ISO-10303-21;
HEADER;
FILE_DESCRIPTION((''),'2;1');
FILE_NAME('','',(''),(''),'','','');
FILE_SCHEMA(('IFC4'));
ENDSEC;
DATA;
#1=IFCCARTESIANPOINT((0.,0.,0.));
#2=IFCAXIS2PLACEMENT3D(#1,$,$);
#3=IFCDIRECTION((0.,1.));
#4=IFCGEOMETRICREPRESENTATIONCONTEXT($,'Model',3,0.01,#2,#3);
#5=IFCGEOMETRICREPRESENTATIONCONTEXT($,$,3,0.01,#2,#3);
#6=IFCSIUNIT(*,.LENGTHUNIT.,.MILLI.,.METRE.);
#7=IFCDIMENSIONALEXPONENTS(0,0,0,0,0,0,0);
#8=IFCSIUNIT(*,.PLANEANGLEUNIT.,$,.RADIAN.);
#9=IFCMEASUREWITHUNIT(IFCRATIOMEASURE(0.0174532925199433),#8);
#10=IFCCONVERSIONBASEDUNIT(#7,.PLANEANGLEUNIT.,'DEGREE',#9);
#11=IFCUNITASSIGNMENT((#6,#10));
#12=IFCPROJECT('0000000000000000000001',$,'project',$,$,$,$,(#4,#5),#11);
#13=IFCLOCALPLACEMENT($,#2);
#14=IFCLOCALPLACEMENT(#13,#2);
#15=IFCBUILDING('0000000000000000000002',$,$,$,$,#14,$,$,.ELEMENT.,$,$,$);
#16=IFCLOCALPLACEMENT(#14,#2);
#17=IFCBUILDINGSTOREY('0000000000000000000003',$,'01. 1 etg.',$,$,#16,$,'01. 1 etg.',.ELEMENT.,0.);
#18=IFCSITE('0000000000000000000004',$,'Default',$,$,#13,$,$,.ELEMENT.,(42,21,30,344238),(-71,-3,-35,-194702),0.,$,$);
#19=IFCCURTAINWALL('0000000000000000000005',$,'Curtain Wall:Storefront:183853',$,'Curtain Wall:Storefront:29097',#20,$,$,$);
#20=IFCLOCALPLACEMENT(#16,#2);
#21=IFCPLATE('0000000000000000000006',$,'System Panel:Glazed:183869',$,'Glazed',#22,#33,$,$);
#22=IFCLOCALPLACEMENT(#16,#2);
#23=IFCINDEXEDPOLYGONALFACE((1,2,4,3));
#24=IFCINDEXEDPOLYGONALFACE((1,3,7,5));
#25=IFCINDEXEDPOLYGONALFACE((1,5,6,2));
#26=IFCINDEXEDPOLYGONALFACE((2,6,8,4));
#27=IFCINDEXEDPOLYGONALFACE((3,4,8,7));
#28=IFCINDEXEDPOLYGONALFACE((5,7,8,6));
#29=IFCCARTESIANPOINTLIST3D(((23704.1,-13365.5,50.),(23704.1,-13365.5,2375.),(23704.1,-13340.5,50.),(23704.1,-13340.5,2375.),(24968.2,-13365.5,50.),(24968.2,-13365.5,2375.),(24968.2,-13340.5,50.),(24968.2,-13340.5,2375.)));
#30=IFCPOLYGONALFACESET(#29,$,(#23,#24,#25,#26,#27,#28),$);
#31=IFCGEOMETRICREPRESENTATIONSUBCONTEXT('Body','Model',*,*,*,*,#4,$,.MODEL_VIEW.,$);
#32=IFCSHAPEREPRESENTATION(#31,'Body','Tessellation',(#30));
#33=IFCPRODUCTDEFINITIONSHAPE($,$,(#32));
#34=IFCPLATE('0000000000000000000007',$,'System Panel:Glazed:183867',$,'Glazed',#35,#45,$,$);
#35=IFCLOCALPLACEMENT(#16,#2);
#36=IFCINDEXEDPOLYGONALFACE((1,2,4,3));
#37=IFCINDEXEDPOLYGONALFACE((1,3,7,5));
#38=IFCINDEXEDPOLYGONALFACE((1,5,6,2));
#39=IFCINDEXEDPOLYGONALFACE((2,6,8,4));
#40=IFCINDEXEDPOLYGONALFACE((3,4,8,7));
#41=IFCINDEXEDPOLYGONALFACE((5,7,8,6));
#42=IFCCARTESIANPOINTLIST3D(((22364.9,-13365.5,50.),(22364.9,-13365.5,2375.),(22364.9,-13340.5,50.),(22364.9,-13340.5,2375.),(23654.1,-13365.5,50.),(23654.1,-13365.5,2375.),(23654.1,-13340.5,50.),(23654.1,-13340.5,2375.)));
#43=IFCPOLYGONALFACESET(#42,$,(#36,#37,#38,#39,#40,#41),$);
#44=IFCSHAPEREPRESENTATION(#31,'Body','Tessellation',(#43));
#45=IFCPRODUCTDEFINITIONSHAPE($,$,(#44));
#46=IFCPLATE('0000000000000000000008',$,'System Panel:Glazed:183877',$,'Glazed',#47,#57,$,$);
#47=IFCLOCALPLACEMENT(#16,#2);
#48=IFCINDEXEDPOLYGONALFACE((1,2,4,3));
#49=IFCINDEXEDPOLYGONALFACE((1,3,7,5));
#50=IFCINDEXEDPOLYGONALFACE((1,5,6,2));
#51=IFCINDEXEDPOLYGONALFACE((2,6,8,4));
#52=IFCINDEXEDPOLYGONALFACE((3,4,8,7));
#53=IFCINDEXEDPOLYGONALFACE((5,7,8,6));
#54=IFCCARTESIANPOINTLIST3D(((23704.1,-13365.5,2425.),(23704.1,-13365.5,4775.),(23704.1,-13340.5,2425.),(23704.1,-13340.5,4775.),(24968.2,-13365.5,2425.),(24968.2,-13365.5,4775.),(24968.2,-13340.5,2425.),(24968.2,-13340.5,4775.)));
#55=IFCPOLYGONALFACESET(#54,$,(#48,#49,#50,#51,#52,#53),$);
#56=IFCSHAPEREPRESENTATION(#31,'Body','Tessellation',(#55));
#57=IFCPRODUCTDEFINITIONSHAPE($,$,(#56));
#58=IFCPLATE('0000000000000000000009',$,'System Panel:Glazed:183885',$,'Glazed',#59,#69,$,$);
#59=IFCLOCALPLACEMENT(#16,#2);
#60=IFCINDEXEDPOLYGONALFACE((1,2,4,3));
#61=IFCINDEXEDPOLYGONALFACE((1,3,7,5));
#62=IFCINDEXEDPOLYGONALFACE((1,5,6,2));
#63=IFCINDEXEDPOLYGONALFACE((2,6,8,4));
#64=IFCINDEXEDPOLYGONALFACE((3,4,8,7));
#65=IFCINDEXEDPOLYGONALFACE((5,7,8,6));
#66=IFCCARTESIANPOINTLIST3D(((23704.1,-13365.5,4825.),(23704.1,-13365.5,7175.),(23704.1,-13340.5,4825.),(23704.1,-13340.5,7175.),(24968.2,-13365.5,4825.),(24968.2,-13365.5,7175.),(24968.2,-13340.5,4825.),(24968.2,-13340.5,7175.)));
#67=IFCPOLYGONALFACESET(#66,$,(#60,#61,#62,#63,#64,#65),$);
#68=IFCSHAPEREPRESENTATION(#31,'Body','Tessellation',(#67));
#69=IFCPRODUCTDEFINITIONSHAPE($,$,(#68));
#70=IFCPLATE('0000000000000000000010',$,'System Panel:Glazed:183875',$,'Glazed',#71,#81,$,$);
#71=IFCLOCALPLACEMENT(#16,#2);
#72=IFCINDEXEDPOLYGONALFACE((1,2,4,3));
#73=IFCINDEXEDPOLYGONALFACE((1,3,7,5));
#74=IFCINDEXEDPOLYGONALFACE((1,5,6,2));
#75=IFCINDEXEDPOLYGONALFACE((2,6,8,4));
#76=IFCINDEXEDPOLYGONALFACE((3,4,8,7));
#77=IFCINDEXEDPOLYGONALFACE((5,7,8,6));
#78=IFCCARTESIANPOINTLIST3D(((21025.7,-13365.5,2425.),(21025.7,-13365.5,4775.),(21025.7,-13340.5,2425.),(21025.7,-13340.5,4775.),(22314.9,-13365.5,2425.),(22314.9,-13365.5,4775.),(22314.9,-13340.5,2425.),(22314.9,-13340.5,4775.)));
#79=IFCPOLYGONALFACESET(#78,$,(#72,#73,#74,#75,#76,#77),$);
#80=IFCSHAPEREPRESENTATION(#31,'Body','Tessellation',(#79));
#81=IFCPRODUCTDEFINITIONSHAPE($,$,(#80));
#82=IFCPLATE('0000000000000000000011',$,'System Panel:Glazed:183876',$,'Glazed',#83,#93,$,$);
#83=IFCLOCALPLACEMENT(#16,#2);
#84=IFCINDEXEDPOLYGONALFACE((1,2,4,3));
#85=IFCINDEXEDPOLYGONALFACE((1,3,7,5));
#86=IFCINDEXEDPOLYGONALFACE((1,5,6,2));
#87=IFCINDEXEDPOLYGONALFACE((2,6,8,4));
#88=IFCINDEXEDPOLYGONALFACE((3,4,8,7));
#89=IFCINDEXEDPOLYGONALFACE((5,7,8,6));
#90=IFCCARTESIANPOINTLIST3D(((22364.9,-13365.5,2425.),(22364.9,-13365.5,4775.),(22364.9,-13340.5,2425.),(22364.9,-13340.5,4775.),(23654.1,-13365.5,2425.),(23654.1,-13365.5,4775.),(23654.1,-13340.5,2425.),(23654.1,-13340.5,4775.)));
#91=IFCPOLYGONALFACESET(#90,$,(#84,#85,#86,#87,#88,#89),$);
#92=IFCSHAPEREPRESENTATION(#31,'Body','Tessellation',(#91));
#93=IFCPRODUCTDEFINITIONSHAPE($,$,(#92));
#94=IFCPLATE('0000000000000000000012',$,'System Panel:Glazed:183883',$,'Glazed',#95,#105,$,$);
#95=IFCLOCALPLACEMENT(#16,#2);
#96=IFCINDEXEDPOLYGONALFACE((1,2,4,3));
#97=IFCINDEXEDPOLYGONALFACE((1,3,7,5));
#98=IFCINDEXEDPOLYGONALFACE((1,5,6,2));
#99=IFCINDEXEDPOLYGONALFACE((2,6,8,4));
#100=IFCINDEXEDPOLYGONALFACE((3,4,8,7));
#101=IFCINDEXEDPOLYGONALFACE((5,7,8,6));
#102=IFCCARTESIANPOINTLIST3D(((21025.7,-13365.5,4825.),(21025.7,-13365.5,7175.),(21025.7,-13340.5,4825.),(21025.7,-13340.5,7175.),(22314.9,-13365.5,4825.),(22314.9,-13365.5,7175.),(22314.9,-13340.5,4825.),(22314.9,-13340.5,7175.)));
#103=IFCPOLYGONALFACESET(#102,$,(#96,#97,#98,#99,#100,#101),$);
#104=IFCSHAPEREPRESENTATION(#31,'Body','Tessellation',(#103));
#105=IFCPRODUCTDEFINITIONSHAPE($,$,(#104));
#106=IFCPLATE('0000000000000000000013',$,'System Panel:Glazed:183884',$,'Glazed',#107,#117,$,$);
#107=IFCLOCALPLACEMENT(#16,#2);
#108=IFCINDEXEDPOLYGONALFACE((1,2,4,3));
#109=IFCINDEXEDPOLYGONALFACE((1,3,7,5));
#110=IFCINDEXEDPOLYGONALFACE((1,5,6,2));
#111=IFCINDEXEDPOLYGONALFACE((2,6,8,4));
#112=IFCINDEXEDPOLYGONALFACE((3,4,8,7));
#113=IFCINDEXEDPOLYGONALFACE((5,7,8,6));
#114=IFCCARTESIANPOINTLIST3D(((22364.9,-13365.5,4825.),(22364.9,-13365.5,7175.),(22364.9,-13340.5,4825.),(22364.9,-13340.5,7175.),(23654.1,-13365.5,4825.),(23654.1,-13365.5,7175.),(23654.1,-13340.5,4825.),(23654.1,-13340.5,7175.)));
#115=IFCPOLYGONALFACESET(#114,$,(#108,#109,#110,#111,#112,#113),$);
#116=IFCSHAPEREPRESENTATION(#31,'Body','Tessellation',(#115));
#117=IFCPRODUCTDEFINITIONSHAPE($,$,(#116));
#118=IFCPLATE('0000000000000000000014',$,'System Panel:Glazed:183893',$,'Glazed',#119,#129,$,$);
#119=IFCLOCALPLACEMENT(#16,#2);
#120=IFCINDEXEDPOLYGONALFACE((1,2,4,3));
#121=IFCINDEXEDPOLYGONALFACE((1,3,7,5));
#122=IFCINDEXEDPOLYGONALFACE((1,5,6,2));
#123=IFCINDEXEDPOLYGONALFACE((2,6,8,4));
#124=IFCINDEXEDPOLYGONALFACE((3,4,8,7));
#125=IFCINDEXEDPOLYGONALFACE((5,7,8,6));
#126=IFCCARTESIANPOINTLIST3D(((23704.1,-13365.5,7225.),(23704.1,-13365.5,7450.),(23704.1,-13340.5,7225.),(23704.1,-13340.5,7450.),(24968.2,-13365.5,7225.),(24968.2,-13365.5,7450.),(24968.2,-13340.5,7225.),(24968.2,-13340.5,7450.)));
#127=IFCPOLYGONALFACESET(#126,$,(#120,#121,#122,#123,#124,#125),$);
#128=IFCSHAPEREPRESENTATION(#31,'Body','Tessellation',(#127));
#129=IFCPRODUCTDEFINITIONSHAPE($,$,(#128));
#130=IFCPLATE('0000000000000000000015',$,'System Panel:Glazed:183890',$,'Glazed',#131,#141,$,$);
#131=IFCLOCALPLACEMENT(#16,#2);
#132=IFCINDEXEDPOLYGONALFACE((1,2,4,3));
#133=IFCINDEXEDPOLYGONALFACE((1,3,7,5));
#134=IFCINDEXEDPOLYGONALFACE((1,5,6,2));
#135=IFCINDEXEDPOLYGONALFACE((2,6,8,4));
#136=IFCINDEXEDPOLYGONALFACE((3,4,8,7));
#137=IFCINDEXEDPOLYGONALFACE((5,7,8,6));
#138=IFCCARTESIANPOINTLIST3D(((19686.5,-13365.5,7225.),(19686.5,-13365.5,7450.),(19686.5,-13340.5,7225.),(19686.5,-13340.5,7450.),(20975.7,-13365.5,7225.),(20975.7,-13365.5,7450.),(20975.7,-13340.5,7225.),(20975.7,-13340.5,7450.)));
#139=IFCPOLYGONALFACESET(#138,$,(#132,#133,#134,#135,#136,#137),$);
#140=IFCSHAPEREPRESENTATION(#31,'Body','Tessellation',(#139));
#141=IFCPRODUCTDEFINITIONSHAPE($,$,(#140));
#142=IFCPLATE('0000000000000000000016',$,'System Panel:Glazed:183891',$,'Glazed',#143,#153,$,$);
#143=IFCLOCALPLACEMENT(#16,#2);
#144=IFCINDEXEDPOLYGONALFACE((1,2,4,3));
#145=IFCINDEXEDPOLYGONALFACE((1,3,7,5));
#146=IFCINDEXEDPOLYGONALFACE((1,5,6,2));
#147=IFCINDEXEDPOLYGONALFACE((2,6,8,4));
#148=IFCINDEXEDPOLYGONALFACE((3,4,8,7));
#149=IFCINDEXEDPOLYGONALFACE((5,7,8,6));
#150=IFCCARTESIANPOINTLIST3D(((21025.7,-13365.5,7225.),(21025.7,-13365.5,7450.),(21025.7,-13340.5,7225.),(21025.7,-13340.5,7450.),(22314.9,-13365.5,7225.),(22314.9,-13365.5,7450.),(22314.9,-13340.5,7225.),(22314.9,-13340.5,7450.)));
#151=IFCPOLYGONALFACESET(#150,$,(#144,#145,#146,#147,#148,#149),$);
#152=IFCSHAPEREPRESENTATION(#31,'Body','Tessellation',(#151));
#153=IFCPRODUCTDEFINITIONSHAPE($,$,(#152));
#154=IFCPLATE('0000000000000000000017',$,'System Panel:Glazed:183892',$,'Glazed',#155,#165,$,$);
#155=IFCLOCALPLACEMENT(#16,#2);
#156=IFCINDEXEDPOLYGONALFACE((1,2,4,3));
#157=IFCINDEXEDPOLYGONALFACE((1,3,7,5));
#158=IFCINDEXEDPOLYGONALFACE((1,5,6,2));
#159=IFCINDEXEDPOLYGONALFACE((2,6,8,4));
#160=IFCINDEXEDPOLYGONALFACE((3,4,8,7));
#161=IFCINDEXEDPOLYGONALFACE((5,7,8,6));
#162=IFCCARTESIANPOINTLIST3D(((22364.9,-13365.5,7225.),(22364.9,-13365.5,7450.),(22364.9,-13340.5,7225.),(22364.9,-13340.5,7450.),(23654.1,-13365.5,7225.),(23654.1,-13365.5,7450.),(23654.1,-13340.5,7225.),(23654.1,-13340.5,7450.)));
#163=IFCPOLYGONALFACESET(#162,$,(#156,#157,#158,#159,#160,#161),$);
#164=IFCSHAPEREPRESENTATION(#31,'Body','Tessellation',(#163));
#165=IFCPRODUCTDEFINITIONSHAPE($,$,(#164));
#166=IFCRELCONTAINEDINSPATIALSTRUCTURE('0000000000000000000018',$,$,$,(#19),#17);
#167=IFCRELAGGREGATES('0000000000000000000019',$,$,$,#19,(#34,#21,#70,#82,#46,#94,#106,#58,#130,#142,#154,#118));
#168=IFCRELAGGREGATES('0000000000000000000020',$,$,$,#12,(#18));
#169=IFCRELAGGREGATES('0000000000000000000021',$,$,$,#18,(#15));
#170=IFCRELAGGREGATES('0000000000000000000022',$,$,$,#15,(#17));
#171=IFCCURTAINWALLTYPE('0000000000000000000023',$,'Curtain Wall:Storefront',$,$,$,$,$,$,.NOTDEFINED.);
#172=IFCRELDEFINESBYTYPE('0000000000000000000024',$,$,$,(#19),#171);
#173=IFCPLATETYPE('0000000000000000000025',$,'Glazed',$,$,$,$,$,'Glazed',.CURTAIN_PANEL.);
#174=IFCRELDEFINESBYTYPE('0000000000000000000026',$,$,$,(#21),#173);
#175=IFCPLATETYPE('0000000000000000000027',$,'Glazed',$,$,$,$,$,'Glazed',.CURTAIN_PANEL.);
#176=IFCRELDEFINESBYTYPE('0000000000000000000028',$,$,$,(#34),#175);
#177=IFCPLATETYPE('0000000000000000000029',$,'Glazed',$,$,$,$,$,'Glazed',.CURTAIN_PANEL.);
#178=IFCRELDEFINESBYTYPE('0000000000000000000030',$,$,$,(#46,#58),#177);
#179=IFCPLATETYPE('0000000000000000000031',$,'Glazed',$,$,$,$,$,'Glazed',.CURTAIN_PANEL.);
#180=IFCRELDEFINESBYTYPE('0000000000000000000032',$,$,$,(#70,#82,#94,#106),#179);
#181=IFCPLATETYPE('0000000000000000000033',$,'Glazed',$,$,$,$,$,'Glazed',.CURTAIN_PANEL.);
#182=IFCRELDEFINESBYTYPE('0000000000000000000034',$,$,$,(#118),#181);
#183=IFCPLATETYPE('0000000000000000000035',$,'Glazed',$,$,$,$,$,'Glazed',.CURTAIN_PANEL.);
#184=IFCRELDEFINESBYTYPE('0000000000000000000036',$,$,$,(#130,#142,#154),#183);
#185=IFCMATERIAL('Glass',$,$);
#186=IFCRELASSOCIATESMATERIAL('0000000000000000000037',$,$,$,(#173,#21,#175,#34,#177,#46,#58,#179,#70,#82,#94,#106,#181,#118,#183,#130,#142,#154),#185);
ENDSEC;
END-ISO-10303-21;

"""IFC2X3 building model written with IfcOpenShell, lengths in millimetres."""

from ifc_helpers import new_model, entity, si_unit, converted_unit, direction, frame, origin, origin_2d_with_axis, place, context, subcontext, project, spatial, rectangle, extrude, source, transform, mapped, material, type_object, type_shapes, element, aggregate, save


model = new_model("IFC2X3")

# Units and contexts
model_context = context("Model", 3, precision=0.01, world=origin(), true_north=direction((0.0, 1.0)))
context_of_model = context(None, 3, precision=0.01, world=origin(), true_north=direction((0.0, 1.0)))
body_context = subcontext(model_context, "Body", "Model", "MODEL_VIEW")
ifc_project = project(units=[si_unit("LENGTHUNIT", "METRE", prefix="MILLI"), converted_unit("PLANEANGLEUNIT", "DEGREE", entity("IfcRatioMeasure", 0.0174532925199433), si_unit("PLANEANGLEUNIT", "RADIAN"), dimensions=[0, 0, 0, 0, 0, 0, 0])], contexts=[model_context, context_of_model])

# Site, building, storey
site_placement = place(None, origin())
site = spatial("IfcSite", under=ifc_project, at=site_placement, Name="Default", CompositionType="ELEMENT", RefLatitude=(42, 21, 30, 344238), RefLongitude=(-71, -3, -35, -194702), RefElevation=0.0)
building_placement = place(site_placement, origin())
building = spatial("IfcBuilding", under=site, at=building_placement, CompositionType="ELEMENT")
storey_placement = place(building_placement, origin())
storey = spatial("IfcBuildingStorey", under=building, at=storey_placement, Name="01. 1 etg.", LongName="01. 1 etg.", CompositionType="ELEMENT", Elevation=0.0)

# Curtain wall, plates
curtain_wall_type = type_object("IfcCurtainWallType", Name="Curtain Wall:Storefront", PredefinedType="NOTDEFINED")
curtain_wall_placement = place(storey_placement, origin())
curtain_wall = element("IfcCurtainWall", 1, at=curtain_wall_placement, inside=storey, type_object=curtain_wall_type, Name="Curtain Wall:Storefront:183853", ObjectType="Curtain Wall:Storefront:29097")
ifc_material_1 = material(Name="Glass")
plate_type_1 = type_object("IfcPlateType", Name="Glazed", ElementType="Glazed", PredefinedType="CURTAIN_PANEL", material=ifc_material_1)
shared_shape_1 = source(origin(), body_context, "Body", "SweptSolid", [
    extrude(rectangle(XDim=25.0, YDim=1264.2, at=origin_2d_with_axis()), frame((632.1, 12.5, 0.0), z_axis=(0.0, 0.0, 1.0), x_axis=(0.0, 1.0, 0.0)), (0.0, 0.0, 1.0), 2325.0),
])
type_shapes(plate_type_1, [shared_shape_1])
plate_1_placement = place(curtain_wall_placement, frame((23704.1, -13365.5, 50.0)))
plate_1 = element("IfcPlate", 2, at=plate_1_placement, type_object=plate_type_1, material=ifc_material_1, Name="System Panel:Glazed:183869", ObjectType="Glazed", context=body_context, shape_type="MappedRepresentation", body=[
    mapped(shared_shape_1, transform((0.0, 0.0, 0.0), scale=1.0)),
])
plate_type_2 = type_object("IfcPlateType", Name="Glazed", ElementType="Glazed", PredefinedType="CURTAIN_PANEL", material=ifc_material_1)
shared_shape_2 = source(origin(), body_context, "Body", "SweptSolid", [
    extrude(rectangle(XDim=25.0, YDim=1289.2, at=origin_2d_with_axis()), frame((644.6, 12.5, 0.0), z_axis=(0.0, 0.0, 1.0), x_axis=(0.0, 1.0, 0.0)), (0.0, 0.0, 1.0), 2325.0),
])
type_shapes(plate_type_2, [shared_shape_2])
plate_2_placement = place(curtain_wall_placement, frame((22364.9, -13365.5, 50.0)))
plate_2 = element("IfcPlate", 3, at=plate_2_placement, type_object=plate_type_2, material=ifc_material_1, Name="System Panel:Glazed:183867", ObjectType="Glazed", context=body_context, shape_type="MappedRepresentation", body=[
    mapped(shared_shape_2, transform((0.0, 0.0, 0.0), scale=1.0)),
])
plate_type_3 = type_object("IfcPlateType", Name="Glazed", ElementType="Glazed", PredefinedType="CURTAIN_PANEL", material=ifc_material_1)
shared_shape_3 = source(origin(), body_context, "Body", "SweptSolid", [
    extrude(rectangle(XDim=25.0, YDim=1264.2, at=origin_2d_with_axis()), frame((632.1, 12.5, 0.0), z_axis=(0.0, 0.0, 1.0), x_axis=(0.0, 1.0, 0.0)), (0.0, 0.0, 1.0), 2350.0),
])
type_shapes(plate_type_3, [shared_shape_3])
plate_3_placement = place(curtain_wall_placement, frame((23704.1, -13365.5, 2425.0)))
plate_3 = element("IfcPlate", 4, at=plate_3_placement, type_object=plate_type_3, material=ifc_material_1, Name="System Panel:Glazed:183877", ObjectType="Glazed", context=body_context, shape_type="MappedRepresentation", body=[
    mapped(shared_shape_3, transform((0.0, 0.0, 0.0), scale=1.0)),
])
plate_4_placement = place(curtain_wall_placement, frame((23704.1, -13365.5, 4825.0)))
plate_4 = element("IfcPlate", 5, at=plate_4_placement, type_object=plate_type_3, material=ifc_material_1, Name="System Panel:Glazed:183885", ObjectType="Glazed", context=body_context, shape_type="MappedRepresentation", body=[
    mapped(shared_shape_3, transform((0.0, 0.0, 0.0), scale=1.0)),
])
plate_type_4 = type_object("IfcPlateType", Name="Glazed", ElementType="Glazed", PredefinedType="CURTAIN_PANEL", material=ifc_material_1)
shared_shape_4 = source(origin(), body_context, "Body", "SweptSolid", [
    extrude(rectangle(XDim=25.0, YDim=1289.2, at=origin_2d_with_axis()), frame((644.6, 12.5, 0.0), z_axis=(0.0, 0.0, 1.0), x_axis=(0.0, 1.0, 0.0)), (0.0, 0.0, 1.0), 2350.0),
])
type_shapes(plate_type_4, [shared_shape_4])
plate_5_placement = place(curtain_wall_placement, frame((21025.7, -13365.5, 2425.0)))
plate_5 = element("IfcPlate", 6, at=plate_5_placement, type_object=plate_type_4, material=ifc_material_1, Name="System Panel:Glazed:183875", ObjectType="Glazed", context=body_context, shape_type="MappedRepresentation", body=[
    mapped(shared_shape_4, transform((0.0, 0.0, 0.0), scale=1.0)),
])
plate_6_placement = place(curtain_wall_placement, frame((22364.9, -13365.5, 2425.0)))
plate_6 = element("IfcPlate", 7, at=plate_6_placement, type_object=plate_type_4, material=ifc_material_1, Name="System Panel:Glazed:183876", ObjectType="Glazed", context=body_context, shape_type="MappedRepresentation", body=[
    mapped(shared_shape_4, transform((0.0, 0.0, 0.0), scale=1.0)),
])
plate_7_placement = place(curtain_wall_placement, frame((21025.7, -13365.5, 4825.0)))
plate_7 = element("IfcPlate", 8, at=plate_7_placement, type_object=plate_type_4, material=ifc_material_1, Name="System Panel:Glazed:183883", ObjectType="Glazed", context=body_context, shape_type="MappedRepresentation", body=[
    mapped(shared_shape_4, transform((0.0, 0.0, 0.0), scale=1.0)),
])
plate_8_placement = place(curtain_wall_placement, frame((22364.9, -13365.5, 4825.0)))
plate_8 = element("IfcPlate", 9, at=plate_8_placement, type_object=plate_type_4, material=ifc_material_1, Name="System Panel:Glazed:183884", ObjectType="Glazed", context=body_context, shape_type="MappedRepresentation", body=[
    mapped(shared_shape_4, transform((0.0, 0.0, 0.0), scale=1.0)),
])
plate_type_5 = type_object("IfcPlateType", Name="Glazed", ElementType="Glazed", PredefinedType="CURTAIN_PANEL", material=ifc_material_1)
shared_shape_5 = source(origin(), body_context, "Body", "SweptSolid", [
    extrude(rectangle(XDim=25.0, YDim=1264.2, at=origin_2d_with_axis()), frame((632.1, 12.5, 0.0), z_axis=(0.0, 0.0, 1.0), x_axis=(0.0, 1.0, 0.0)), (0.0, 0.0, 1.0), 225.0),
])
type_shapes(plate_type_5, [shared_shape_5])
plate_9_placement = place(curtain_wall_placement, frame((23704.1, -13365.5, 7225.0)))
plate_9 = element("IfcPlate", 10, at=plate_9_placement, type_object=plate_type_5, material=ifc_material_1, Name="System Panel:Glazed:183893", ObjectType="Glazed", context=body_context, shape_type="MappedRepresentation", body=[
    mapped(shared_shape_5, transform((0.0, 0.0, 0.0), scale=1.0)),
])
plate_type_6 = type_object("IfcPlateType", Name="Glazed", ElementType="Glazed", PredefinedType="CURTAIN_PANEL", material=ifc_material_1)
shared_shape_6 = source(origin(), body_context, "Body", "SweptSolid", [
    extrude(rectangle(XDim=25.0, YDim=1289.2, at=origin_2d_with_axis()), frame((644.6, 12.5, 0.0), z_axis=(0.0, 0.0, 1.0), x_axis=(0.0, 1.0, 0.0)), (0.0, 0.0, 1.0), 225.0),
])
type_shapes(plate_type_6, [shared_shape_6])
plate_10_placement = place(curtain_wall_placement, frame((19686.5, -13365.5, 7225.0)))
plate_10 = element("IfcPlate", 11, at=plate_10_placement, type_object=plate_type_6, material=ifc_material_1, Name="System Panel:Glazed:183890", ObjectType="Glazed", context=body_context, shape_type="MappedRepresentation", body=[
    mapped(shared_shape_6, transform((0.0, 0.0, 0.0), scale=1.0)),
])
plate_11_placement = place(curtain_wall_placement, frame((21025.7, -13365.5, 7225.0)))
plate_11 = element("IfcPlate", 12, at=plate_11_placement, type_object=plate_type_6, material=ifc_material_1, Name="System Panel:Glazed:183891", ObjectType="Glazed", context=body_context, shape_type="MappedRepresentation", body=[
    mapped(shared_shape_6, transform((0.0, 0.0, 0.0), scale=1.0)),
])
plate_12_placement = place(curtain_wall_placement, frame((22364.9, -13365.5, 7225.0)))
plate_12 = element("IfcPlate", 13, at=plate_12_placement, type_object=plate_type_6, material=ifc_material_1, Name="System Panel:Glazed:183892", ObjectType="Glazed", context=body_context, shape_type="MappedRepresentation", body=[
    mapped(shared_shape_6, transform((0.0, 0.0, 0.0), scale=1.0)),
])
aggregate(curtain_wall, [plate_2, plate_1, plate_5, plate_6, plate_3, plate_7, plate_8, plate_4, plate_10, plate_11, plate_12, plate_9])

save(model, "model.ifc")
